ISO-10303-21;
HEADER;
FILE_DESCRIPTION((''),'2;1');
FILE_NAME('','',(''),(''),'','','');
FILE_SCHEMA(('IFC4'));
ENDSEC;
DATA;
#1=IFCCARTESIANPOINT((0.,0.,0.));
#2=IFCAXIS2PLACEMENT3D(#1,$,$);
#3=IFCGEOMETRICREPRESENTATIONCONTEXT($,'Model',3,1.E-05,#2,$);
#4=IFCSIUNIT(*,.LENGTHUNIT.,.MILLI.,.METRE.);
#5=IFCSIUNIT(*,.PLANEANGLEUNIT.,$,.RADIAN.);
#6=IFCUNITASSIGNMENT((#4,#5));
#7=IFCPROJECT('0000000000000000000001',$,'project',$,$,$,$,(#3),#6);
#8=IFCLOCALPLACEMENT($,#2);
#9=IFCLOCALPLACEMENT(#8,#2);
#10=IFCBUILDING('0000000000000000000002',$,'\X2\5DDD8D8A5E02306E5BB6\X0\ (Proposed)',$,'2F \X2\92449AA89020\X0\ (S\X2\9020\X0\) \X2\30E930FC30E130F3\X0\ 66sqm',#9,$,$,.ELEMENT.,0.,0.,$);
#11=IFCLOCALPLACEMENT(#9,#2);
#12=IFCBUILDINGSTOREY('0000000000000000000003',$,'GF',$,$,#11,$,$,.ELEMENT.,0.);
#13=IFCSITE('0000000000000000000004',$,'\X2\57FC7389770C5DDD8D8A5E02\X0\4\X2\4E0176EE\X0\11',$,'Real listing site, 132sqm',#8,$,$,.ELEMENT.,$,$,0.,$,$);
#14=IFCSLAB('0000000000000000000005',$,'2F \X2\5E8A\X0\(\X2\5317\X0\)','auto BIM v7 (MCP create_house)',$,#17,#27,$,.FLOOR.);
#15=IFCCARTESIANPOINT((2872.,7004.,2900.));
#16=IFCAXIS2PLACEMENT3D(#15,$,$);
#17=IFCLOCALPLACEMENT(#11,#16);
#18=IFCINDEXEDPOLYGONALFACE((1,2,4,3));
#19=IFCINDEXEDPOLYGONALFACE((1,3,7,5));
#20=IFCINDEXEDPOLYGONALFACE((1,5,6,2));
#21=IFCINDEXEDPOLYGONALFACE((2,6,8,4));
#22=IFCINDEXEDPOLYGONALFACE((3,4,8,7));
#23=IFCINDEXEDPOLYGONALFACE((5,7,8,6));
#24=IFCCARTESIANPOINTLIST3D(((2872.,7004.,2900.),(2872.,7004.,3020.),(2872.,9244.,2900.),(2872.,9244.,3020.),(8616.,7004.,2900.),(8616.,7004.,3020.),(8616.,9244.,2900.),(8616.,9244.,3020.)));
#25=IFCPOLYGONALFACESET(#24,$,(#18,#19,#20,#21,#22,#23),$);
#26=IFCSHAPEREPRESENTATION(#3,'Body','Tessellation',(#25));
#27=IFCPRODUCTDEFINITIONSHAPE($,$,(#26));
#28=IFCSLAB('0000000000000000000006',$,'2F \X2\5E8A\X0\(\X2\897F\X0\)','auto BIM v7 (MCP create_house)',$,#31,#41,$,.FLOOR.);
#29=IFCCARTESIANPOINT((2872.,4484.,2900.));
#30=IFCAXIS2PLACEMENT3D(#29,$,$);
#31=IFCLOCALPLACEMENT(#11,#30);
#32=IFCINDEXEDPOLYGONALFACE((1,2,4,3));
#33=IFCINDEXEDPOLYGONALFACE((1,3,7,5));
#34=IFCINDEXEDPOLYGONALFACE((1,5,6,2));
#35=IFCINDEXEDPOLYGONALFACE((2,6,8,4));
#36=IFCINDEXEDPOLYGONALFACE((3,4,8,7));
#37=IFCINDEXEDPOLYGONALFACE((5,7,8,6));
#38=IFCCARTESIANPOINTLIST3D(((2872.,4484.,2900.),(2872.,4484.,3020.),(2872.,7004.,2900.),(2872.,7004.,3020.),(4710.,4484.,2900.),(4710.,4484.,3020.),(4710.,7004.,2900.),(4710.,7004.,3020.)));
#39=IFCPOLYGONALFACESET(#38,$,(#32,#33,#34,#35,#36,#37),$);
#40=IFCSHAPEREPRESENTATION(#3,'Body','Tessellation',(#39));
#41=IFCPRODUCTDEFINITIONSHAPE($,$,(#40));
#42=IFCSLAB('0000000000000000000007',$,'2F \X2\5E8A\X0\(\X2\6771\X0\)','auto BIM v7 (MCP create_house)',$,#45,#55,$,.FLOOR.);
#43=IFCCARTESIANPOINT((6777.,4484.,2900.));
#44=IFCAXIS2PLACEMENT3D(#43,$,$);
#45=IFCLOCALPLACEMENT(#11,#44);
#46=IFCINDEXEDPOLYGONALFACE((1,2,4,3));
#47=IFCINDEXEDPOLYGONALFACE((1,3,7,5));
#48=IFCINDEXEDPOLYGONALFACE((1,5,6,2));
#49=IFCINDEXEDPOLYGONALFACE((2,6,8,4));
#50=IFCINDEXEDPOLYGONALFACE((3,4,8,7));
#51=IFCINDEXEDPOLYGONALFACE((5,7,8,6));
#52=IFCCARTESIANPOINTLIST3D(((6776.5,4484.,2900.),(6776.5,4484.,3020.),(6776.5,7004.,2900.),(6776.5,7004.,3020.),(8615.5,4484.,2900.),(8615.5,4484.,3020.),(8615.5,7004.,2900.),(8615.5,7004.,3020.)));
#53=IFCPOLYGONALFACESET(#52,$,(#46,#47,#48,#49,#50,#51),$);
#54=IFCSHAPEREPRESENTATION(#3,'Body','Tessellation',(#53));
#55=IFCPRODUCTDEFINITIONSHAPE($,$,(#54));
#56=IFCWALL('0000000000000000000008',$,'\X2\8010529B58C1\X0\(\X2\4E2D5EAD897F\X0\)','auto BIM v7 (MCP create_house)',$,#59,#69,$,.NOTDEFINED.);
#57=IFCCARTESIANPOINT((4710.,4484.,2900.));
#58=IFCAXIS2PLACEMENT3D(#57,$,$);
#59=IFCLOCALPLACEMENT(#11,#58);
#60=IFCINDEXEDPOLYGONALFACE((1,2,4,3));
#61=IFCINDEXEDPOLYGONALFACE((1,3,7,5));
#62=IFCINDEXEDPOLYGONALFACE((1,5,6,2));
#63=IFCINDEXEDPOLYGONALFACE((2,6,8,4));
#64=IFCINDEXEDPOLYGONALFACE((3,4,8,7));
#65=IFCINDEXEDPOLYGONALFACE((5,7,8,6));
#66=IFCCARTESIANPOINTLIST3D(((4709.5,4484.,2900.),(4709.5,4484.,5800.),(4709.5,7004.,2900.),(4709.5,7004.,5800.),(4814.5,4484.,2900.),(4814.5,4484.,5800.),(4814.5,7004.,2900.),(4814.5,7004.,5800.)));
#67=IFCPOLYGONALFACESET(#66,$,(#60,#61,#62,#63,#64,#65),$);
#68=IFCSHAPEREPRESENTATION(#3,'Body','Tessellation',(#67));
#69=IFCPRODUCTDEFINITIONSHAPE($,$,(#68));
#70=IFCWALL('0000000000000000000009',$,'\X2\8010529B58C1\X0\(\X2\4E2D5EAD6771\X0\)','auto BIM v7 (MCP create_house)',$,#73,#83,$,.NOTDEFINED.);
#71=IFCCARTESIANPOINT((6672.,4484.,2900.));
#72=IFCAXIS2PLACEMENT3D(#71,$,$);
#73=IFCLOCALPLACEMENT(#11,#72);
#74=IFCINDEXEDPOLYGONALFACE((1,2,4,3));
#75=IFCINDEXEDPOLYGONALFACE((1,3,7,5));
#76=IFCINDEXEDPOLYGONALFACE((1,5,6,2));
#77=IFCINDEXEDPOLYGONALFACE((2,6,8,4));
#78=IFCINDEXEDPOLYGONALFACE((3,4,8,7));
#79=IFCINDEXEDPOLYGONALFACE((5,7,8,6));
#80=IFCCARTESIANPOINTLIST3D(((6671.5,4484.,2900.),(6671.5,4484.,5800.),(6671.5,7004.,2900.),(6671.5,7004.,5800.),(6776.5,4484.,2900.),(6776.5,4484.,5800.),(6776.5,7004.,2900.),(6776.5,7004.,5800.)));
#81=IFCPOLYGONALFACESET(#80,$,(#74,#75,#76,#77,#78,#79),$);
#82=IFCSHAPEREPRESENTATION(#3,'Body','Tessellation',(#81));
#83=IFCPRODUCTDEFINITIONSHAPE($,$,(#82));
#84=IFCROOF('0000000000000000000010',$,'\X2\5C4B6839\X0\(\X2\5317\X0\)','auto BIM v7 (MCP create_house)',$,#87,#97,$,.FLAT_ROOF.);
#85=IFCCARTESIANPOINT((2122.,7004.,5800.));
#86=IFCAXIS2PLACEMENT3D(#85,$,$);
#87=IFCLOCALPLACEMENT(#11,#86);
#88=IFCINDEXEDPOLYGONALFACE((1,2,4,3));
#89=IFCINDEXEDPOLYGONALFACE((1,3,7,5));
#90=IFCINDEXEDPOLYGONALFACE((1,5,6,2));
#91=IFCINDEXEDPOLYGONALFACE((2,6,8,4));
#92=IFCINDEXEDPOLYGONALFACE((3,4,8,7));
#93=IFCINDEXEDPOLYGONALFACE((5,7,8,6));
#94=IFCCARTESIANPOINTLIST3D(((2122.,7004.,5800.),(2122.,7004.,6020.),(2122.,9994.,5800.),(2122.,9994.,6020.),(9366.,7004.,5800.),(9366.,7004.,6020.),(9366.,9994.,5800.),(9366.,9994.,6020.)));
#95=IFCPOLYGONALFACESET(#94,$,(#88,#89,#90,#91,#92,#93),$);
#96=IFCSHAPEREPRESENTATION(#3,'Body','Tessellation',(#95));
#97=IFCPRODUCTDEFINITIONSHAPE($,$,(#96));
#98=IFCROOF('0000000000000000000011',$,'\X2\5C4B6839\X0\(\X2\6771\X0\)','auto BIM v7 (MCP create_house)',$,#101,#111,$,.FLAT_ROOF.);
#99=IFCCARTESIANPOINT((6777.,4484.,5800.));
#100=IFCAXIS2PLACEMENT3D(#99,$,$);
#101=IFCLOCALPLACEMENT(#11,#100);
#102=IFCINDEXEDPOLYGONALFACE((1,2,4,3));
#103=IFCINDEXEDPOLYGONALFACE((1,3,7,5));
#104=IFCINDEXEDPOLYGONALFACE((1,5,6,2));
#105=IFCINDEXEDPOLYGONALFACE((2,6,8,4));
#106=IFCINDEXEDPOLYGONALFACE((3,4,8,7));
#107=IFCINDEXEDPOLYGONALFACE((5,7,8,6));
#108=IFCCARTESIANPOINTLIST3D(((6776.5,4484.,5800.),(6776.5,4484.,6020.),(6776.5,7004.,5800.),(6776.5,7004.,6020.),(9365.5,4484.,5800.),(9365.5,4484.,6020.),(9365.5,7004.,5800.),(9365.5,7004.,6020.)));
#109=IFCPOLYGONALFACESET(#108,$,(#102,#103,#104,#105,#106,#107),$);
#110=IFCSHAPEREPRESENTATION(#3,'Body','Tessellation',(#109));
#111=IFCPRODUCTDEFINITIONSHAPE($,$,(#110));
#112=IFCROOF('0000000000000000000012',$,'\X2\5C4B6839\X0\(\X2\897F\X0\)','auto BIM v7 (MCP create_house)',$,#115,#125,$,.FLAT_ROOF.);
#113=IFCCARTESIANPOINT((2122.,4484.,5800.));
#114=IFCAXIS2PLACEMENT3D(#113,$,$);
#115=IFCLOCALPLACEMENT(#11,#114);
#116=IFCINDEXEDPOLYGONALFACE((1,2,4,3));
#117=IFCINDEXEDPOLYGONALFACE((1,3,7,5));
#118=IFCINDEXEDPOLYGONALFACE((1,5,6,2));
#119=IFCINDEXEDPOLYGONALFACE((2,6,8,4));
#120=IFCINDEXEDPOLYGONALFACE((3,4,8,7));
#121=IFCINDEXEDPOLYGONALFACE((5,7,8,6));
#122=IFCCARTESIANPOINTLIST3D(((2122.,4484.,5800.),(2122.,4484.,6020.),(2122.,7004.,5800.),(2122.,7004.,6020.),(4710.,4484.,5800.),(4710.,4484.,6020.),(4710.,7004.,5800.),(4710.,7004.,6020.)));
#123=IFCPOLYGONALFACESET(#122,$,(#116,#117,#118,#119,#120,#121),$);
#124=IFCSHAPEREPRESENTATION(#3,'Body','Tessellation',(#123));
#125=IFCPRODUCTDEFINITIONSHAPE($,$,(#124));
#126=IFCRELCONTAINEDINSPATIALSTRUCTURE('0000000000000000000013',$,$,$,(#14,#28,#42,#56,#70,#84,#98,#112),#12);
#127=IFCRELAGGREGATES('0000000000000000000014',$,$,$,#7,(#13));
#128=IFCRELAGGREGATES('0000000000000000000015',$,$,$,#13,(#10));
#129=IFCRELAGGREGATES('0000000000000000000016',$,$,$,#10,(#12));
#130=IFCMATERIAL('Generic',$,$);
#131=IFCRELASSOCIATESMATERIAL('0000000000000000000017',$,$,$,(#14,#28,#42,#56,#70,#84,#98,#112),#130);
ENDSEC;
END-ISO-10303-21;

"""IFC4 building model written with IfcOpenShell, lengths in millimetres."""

from ifc_helpers import new_model, si_unit, frame, frame_2d, origin, place, context, project, spatial, rectangle, extrude, material, element, save


model = new_model("IFC4")

# Units and contexts
model_context = context("Model", 3, precision=1e-05, world=origin())
ifc_project = project(units=[si_unit("LENGTHUNIT", "METRE", prefix="MILLI"), si_unit("PLANEANGLEUNIT", "RADIAN")], contexts=[model_context])

# Site, building, storey
site_placement = place(None, origin())
site = spatial("IfcSite", under=ifc_project, at=site_placement, Name="埼玉県川越市4丁目11", ObjectType="Real listing site, 132sqm", CompositionType="ELEMENT", RefElevation=0.0)
building_placement = place(site_placement, origin())
building = spatial("IfcBuilding", under=site, at=building_placement, Name="川越市の家 (Proposed)", ObjectType="2F 鉄骨造 (S造) ラーメン 66sqm", CompositionType="ELEMENT", ElevationOfRefHeight=0.0, ElevationOfTerrain=0.0)
storey_placement = place(building_placement, origin())
storey = spatial("IfcBuildingStorey", under=building, at=storey_placement, Name="GF", CompositionType="ELEMENT", Elevation=0.0)

# Slabs
ifc_material = material(Name="Generic")
slab_1_placement = place(storey_placement, frame((2872.0, 7004.0, 2900.0)))
element("IfcSlab", 1, at=slab_1_placement, inside=storey, material=ifc_material, Name="2F 床(北)", Description="auto BIM v7 (MCP create_house)", PredefinedType="FLOOR", context=model_context, shape_type="SweptSolid", body=[
    extrude(rectangle(XDim=5744.0, YDim=2240.0, at=frame_2d((2872.0, 1120.0))), frame((2872.0, 7004.0, 2900.0)), (0.0, 0.0, 1.0), 120.0),
])
slab_2_placement = place(storey_placement, frame((2872.0, 4484.0, 2900.0)))
element("IfcSlab", 2, at=slab_2_placement, inside=storey, material=ifc_material, Name="2F 床(西)", Description="auto BIM v7 (MCP create_house)", PredefinedType="FLOOR", context=model_context, shape_type="SweptSolid", body=[
    extrude(rectangle(XDim=1838.0, YDim=2520.0, at=frame_2d((919.0, 1260.0))), frame((2872.0, 4484.0, 2900.0)), (0.0, 0.0, 1.0), 120.0),
])
slab_3_placement = place(storey_placement, frame((6777.0, 4484.0, 2900.0)))
element("IfcSlab", 3, at=slab_3_placement, inside=storey, material=ifc_material, Name="2F 床(東)", Description="auto BIM v7 (MCP create_house)", PredefinedType="FLOOR", context=model_context, shape_type="SweptSolid", body=[
    extrude(rectangle(XDim=1839.0, YDim=2520.0, at=frame_2d((919.0, 1260.0))), frame((6777.0, 4484.0, 2900.0)), (0.0, 0.0, 1.0), 120.0),
])

# Walls
wall_1_placement = place(storey_placement, frame((4710.0, 4484.0, 2900.0)))
element("IfcWall", 4, at=wall_1_placement, inside=storey, material=ifc_material, Name="耐力壁(中庭西)", Description="auto BIM v7 (MCP create_house)", PredefinedType="NOTDEFINED", context=model_context, shape_type="SweptSolid", body=[
    extrude(rectangle(XDim=105.0, YDim=2520.0, at=frame_2d((52.0, 1260.0))), frame((4710.0, 4484.0, 2900.0)), (0.0, 0.0, 1.0), 2900.0),
])
wall_2_placement = place(storey_placement, frame((6672.0, 4484.0, 2900.0)))
element("IfcWall", 5, at=wall_2_placement, inside=storey, material=ifc_material, Name="耐力壁(中庭東)", Description="auto BIM v7 (MCP create_house)", PredefinedType="NOTDEFINED", context=model_context, shape_type="SweptSolid", body=[
    extrude(rectangle(XDim=105.0, YDim=2520.0, at=frame_2d((52.0, 1260.0))), frame((6672.0, 4484.0, 2900.0)), (0.0, 0.0, 1.0), 2900.0),
])

# Roofs
roof_1_placement = place(storey_placement, frame((2122.0, 7004.0, 5800.0)))
element("IfcRoof", 6, at=roof_1_placement, inside=storey, material=ifc_material, Name="屋根(北)", Description="auto BIM v7 (MCP create_house)", PredefinedType="FLAT_ROOF", context=model_context, shape_type="SweptSolid", body=[
    extrude(rectangle(XDim=7244.0, YDim=2990.0, at=frame_2d((3622.0, 1495.0))), frame((2122.0, 7004.0, 5800.0)), (0.0, 0.0, 1.0), 220.0),
])
roof_2_placement = place(storey_placement, frame((6777.0, 4484.0, 5800.0)))
element("IfcRoof", 7, at=roof_2_placement, inside=storey, material=ifc_material, Name="屋根(東)", Description="auto BIM v7 (MCP create_house)", PredefinedType="FLAT_ROOF", context=model_context, shape_type="SweptSolid", body=[
    extrude(rectangle(XDim=2589.0, YDim=2520.0, at=frame_2d((1294.0, 1260.0))), frame((6777.0, 4484.0, 5800.0)), (0.0, 0.0, 1.0), 220.0),
])
roof_3_placement = place(storey_placement, frame((2122.0, 4484.0, 5800.0)))
element("IfcRoof", 8, at=roof_3_placement, inside=storey, material=ifc_material, Name="屋根(西)", Description="auto BIM v7 (MCP create_house)", PredefinedType="FLAT_ROOF", context=model_context, shape_type="SweptSolid", body=[
    extrude(rectangle(XDim=2588.0, YDim=2520.0, at=frame_2d((1294.0, 1260.0))), frame((2122.0, 4484.0, 5800.0)), (0.0, 0.0, 1.0), 220.0),
])

save(model, "model.ifc")
